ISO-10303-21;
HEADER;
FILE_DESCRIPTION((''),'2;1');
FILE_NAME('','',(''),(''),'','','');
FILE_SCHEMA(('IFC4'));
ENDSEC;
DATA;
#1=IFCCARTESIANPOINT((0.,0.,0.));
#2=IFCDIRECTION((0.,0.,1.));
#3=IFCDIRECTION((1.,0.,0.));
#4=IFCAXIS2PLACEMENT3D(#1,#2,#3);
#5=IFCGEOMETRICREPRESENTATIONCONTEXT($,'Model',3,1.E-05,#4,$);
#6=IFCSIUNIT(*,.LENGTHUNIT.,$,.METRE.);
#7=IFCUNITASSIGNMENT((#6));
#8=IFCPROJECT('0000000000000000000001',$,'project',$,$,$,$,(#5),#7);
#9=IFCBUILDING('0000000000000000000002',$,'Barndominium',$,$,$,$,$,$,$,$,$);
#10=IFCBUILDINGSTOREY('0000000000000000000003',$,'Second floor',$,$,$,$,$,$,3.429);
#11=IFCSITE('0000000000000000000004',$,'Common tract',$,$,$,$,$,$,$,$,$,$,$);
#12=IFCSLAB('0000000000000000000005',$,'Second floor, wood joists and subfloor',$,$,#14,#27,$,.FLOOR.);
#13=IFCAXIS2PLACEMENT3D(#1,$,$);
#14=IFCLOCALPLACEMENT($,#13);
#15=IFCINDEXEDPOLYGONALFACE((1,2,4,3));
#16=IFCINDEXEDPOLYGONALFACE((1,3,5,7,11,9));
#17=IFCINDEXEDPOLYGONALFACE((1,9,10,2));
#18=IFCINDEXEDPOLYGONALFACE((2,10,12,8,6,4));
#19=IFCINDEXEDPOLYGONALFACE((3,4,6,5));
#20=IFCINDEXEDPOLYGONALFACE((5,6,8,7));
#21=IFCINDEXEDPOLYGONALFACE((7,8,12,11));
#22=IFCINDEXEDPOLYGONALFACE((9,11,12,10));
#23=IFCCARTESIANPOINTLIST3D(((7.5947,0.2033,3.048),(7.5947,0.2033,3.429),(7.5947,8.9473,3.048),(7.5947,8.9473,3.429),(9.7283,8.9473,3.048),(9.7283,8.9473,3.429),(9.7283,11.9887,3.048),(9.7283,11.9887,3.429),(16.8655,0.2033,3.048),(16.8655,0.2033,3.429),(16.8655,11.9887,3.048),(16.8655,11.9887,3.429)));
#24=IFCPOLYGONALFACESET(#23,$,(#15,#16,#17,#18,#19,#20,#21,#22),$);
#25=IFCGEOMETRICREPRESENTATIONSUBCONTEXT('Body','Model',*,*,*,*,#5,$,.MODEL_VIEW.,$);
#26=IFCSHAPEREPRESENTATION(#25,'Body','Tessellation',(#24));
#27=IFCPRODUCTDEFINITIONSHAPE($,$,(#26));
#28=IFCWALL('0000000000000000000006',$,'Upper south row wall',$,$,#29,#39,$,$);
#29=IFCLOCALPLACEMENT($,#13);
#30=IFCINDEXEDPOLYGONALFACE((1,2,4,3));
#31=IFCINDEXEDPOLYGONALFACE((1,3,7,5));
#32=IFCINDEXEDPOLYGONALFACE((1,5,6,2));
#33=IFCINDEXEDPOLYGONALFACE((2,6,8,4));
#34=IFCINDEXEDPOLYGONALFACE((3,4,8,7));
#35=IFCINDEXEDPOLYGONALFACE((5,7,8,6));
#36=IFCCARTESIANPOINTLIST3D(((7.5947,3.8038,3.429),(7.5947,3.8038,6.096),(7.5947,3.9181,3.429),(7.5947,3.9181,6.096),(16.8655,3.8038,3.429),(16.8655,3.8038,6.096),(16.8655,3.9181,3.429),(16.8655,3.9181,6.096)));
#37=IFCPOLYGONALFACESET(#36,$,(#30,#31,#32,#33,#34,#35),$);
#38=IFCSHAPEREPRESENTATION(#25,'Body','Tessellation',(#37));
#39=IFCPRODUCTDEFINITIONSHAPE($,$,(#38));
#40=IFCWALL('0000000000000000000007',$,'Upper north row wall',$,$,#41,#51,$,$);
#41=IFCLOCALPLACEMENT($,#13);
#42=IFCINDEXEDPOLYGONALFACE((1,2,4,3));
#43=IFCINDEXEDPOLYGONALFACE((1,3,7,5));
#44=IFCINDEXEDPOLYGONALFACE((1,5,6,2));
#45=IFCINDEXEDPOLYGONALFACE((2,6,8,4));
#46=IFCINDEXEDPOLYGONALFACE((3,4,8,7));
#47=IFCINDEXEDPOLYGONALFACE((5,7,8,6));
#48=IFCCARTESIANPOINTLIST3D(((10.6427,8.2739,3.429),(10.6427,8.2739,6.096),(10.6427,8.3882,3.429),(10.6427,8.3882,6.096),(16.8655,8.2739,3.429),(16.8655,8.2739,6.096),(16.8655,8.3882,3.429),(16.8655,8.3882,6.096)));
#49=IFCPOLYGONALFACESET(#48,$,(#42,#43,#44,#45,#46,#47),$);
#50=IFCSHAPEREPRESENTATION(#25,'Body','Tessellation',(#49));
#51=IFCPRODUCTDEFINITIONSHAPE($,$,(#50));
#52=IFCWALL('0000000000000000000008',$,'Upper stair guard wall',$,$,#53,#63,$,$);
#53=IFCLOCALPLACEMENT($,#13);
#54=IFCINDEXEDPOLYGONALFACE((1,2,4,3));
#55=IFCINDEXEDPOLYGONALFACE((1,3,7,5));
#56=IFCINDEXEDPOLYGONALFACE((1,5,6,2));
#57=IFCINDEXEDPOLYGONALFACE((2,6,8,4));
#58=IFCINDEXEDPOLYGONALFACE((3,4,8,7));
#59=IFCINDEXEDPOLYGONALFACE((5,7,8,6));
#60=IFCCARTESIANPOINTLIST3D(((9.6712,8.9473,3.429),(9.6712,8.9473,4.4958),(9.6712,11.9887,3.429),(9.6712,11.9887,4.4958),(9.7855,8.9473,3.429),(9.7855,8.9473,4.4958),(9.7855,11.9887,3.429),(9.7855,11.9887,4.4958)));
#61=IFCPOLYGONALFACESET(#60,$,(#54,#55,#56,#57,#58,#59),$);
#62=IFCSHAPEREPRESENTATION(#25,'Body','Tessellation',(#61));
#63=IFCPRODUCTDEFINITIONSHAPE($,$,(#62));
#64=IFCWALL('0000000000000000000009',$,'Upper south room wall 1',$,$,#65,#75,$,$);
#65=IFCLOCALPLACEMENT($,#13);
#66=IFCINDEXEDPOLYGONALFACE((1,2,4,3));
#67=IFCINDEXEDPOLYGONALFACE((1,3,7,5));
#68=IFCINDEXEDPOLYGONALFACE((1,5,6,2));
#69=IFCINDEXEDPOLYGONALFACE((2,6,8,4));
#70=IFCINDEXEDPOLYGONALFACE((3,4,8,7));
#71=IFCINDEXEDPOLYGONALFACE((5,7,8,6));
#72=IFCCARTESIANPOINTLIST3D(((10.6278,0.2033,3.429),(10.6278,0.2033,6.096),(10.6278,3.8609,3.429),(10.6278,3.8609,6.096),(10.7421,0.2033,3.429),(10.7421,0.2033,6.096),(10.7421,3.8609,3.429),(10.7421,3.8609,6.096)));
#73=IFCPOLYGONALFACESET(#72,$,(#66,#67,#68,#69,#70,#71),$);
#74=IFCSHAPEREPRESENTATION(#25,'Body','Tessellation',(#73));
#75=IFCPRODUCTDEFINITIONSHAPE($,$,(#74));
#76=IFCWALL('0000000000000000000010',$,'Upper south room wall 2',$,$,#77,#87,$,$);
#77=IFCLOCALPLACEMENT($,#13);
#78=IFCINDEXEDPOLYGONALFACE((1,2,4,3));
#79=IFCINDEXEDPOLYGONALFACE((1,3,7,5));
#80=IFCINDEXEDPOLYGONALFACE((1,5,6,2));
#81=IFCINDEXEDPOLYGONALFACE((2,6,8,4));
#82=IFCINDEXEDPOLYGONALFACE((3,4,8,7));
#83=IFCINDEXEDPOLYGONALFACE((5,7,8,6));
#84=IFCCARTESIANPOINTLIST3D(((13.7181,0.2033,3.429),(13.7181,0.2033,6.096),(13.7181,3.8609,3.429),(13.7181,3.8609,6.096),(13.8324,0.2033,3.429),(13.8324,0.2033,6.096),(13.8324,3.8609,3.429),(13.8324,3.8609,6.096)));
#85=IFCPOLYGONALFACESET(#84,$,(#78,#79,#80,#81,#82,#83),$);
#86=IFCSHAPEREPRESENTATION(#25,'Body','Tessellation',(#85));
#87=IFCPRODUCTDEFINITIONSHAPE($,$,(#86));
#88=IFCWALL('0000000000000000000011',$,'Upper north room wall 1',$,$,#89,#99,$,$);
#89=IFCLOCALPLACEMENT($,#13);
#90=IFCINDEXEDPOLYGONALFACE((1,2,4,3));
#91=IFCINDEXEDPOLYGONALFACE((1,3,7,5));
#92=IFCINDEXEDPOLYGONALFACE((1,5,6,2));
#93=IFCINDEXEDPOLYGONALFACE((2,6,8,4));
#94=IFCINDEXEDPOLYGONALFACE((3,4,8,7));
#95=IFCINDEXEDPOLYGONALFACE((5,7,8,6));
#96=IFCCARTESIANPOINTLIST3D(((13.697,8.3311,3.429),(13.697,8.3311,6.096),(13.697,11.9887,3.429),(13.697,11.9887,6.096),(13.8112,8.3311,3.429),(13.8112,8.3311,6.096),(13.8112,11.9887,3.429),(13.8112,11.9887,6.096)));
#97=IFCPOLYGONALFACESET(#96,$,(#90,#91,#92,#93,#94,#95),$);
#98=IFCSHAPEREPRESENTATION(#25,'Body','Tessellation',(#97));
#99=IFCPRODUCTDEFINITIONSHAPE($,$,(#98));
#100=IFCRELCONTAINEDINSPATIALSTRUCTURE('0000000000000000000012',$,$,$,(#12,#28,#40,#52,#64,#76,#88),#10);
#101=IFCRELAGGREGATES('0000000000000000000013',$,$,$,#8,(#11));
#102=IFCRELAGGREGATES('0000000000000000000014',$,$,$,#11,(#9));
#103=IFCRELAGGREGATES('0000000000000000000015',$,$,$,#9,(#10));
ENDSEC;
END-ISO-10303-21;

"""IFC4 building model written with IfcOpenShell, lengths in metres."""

from ifc_helpers import new_model, si_unit, frame, origin_with_axes, place, context, subcontext, project, spatial, indexed_curve, rectangle, outline, extrude, element, save


model = new_model("IFC4")

# Units and contexts
model_context = context("Model", 3, precision=1e-05, world=origin_with_axes())
body_context = subcontext(model_context, "Body", "Model", "MODEL_VIEW")
ifc_project = project(units=[si_unit("LENGTHUNIT", "METRE")], contexts=[model_context])

# Site, building, storey
site = spatial("IfcSite", under=ifc_project, Name="Common tract")
building = spatial("IfcBuilding", under=site, Name="Barndominium")
storey = spatial("IfcBuildingStorey", under=building, Name="Second floor", Elevation=3.429)

# Slab, opening
slab_placement = place(None, frame((12.2301, 6.096, 3.048), z_axis=(0.0, 0.0, 1.0), x_axis=(1.0, 0.0, 0.0)))
slab = element("IfcSlab", 1, at=slab_placement, inside=storey, Name="Second floor, wood joists and subfloor", PredefinedType="FLOOR", context=body_context, shape_type="SweptSolid", body=[
    extrude(rectangle(XDim=9.2708, YDim=11.7854), origin_with_axes(), (0.0, 0.0, 1.0), 0.381),
])
opening_placement = place(slab_placement, frame((-3.5686, 4.372, -0.05), z_axis=(0.0, 0.0, 1.0), x_axis=(1.0, 0.0, 0.0)))
element("IfcOpeningElement", 2, at=opening_placement, cuts=slab, context=body_context, shape_type="SweptSolid", body=[
    extrude(rectangle(XDim=2.1336, YDim=3.0414), origin_with_axes(), (0.0, 0.0, 1.0), 0.481),
])

# Walls
wall_1_placement = place(None, frame((7.5947, 3.8038, 3.429), z_axis=(0.0, 0.0, 1.0), x_axis=(1.0, 0.0, 0.0)))
element("IfcWall", 3, at=wall_1_placement, inside=storey, Name="Upper south row wall", context=body_context, shape_type="SweptSolid", body=[
    extrude(outline(indexed_curve([(0.0, 0.0), (0.0, 0.1143), (9.2708, 0.1143), (9.2708, 0.0), (0.0, 0.0)], self_intersect=False)), origin_with_axes(), (0.0, 0.0, 1.0), 2.667),
])
wall_2_placement = place(None, frame((10.6427, 8.2739, 3.429), z_axis=(0.0, 0.0, 1.0), x_axis=(1.0, 0.0, 0.0)))
element("IfcWall", 4, at=wall_2_placement, inside=storey, Name="Upper north row wall", context=body_context, shape_type="SweptSolid", body=[
    extrude(outline(indexed_curve([(0.0, 0.0), (0.0, 0.1143), (6.2228, 0.1143), (6.2228, 0.0), (0.0, 0.0)], self_intersect=False)), origin_with_axes(), (0.0, 0.0, 1.0), 2.667),
])
wall_3_placement = place(None, frame((9.7855, 8.9473, 3.429), z_axis=(0.0, 0.0, 1.0), x_axis=(0.0, 1.0, 0.0)))
element("IfcWall", 5, at=wall_3_placement, inside=storey, Name="Upper stair guard wall", context=body_context, shape_type="SweptSolid", body=[
    extrude(outline(indexed_curve([(0.0, 0.0), (0.0, 0.1143), (3.0414, 0.1143), (3.0414, 0.0), (0.0, 0.0)], self_intersect=False)), origin_with_axes(), (0.0, 0.0, 1.0), 1.0668),
])
for number, where, z_axis, x_axis, name in (
    (6, (10.7421, 0.2033, 3.429), (0.0, 0.0, 1.0), (0.0, 1.0, 0.0), "Upper south room wall 1"),
    (7, (13.8324, 0.2033, 3.429), (0.0, 0.0, 1.0), (0.0, 1.0, 0.0), "Upper south room wall 2"),
    (8, (13.8113, 8.3311, 3.429), (0.0, 0.0, 1.0), (0.0, 1.0, 0.0), "Upper north room wall 1"),
):
    element("IfcWall", number, at=place(None, frame(where, z_axis=z_axis, x_axis=x_axis)), inside=storey, Name=name, context=body_context, shape_type="SweptSolid", body=[
        extrude(outline(indexed_curve([(0.0, 0.0), (0.0, 0.1143), (3.6576, 0.1143), (3.6576, 0.0), (0.0, 0.0)], self_intersect=False)), origin_with_axes(), (0.0, 0.0, 1.0), 2.667),
    ])

save(model, "model.ifc")
